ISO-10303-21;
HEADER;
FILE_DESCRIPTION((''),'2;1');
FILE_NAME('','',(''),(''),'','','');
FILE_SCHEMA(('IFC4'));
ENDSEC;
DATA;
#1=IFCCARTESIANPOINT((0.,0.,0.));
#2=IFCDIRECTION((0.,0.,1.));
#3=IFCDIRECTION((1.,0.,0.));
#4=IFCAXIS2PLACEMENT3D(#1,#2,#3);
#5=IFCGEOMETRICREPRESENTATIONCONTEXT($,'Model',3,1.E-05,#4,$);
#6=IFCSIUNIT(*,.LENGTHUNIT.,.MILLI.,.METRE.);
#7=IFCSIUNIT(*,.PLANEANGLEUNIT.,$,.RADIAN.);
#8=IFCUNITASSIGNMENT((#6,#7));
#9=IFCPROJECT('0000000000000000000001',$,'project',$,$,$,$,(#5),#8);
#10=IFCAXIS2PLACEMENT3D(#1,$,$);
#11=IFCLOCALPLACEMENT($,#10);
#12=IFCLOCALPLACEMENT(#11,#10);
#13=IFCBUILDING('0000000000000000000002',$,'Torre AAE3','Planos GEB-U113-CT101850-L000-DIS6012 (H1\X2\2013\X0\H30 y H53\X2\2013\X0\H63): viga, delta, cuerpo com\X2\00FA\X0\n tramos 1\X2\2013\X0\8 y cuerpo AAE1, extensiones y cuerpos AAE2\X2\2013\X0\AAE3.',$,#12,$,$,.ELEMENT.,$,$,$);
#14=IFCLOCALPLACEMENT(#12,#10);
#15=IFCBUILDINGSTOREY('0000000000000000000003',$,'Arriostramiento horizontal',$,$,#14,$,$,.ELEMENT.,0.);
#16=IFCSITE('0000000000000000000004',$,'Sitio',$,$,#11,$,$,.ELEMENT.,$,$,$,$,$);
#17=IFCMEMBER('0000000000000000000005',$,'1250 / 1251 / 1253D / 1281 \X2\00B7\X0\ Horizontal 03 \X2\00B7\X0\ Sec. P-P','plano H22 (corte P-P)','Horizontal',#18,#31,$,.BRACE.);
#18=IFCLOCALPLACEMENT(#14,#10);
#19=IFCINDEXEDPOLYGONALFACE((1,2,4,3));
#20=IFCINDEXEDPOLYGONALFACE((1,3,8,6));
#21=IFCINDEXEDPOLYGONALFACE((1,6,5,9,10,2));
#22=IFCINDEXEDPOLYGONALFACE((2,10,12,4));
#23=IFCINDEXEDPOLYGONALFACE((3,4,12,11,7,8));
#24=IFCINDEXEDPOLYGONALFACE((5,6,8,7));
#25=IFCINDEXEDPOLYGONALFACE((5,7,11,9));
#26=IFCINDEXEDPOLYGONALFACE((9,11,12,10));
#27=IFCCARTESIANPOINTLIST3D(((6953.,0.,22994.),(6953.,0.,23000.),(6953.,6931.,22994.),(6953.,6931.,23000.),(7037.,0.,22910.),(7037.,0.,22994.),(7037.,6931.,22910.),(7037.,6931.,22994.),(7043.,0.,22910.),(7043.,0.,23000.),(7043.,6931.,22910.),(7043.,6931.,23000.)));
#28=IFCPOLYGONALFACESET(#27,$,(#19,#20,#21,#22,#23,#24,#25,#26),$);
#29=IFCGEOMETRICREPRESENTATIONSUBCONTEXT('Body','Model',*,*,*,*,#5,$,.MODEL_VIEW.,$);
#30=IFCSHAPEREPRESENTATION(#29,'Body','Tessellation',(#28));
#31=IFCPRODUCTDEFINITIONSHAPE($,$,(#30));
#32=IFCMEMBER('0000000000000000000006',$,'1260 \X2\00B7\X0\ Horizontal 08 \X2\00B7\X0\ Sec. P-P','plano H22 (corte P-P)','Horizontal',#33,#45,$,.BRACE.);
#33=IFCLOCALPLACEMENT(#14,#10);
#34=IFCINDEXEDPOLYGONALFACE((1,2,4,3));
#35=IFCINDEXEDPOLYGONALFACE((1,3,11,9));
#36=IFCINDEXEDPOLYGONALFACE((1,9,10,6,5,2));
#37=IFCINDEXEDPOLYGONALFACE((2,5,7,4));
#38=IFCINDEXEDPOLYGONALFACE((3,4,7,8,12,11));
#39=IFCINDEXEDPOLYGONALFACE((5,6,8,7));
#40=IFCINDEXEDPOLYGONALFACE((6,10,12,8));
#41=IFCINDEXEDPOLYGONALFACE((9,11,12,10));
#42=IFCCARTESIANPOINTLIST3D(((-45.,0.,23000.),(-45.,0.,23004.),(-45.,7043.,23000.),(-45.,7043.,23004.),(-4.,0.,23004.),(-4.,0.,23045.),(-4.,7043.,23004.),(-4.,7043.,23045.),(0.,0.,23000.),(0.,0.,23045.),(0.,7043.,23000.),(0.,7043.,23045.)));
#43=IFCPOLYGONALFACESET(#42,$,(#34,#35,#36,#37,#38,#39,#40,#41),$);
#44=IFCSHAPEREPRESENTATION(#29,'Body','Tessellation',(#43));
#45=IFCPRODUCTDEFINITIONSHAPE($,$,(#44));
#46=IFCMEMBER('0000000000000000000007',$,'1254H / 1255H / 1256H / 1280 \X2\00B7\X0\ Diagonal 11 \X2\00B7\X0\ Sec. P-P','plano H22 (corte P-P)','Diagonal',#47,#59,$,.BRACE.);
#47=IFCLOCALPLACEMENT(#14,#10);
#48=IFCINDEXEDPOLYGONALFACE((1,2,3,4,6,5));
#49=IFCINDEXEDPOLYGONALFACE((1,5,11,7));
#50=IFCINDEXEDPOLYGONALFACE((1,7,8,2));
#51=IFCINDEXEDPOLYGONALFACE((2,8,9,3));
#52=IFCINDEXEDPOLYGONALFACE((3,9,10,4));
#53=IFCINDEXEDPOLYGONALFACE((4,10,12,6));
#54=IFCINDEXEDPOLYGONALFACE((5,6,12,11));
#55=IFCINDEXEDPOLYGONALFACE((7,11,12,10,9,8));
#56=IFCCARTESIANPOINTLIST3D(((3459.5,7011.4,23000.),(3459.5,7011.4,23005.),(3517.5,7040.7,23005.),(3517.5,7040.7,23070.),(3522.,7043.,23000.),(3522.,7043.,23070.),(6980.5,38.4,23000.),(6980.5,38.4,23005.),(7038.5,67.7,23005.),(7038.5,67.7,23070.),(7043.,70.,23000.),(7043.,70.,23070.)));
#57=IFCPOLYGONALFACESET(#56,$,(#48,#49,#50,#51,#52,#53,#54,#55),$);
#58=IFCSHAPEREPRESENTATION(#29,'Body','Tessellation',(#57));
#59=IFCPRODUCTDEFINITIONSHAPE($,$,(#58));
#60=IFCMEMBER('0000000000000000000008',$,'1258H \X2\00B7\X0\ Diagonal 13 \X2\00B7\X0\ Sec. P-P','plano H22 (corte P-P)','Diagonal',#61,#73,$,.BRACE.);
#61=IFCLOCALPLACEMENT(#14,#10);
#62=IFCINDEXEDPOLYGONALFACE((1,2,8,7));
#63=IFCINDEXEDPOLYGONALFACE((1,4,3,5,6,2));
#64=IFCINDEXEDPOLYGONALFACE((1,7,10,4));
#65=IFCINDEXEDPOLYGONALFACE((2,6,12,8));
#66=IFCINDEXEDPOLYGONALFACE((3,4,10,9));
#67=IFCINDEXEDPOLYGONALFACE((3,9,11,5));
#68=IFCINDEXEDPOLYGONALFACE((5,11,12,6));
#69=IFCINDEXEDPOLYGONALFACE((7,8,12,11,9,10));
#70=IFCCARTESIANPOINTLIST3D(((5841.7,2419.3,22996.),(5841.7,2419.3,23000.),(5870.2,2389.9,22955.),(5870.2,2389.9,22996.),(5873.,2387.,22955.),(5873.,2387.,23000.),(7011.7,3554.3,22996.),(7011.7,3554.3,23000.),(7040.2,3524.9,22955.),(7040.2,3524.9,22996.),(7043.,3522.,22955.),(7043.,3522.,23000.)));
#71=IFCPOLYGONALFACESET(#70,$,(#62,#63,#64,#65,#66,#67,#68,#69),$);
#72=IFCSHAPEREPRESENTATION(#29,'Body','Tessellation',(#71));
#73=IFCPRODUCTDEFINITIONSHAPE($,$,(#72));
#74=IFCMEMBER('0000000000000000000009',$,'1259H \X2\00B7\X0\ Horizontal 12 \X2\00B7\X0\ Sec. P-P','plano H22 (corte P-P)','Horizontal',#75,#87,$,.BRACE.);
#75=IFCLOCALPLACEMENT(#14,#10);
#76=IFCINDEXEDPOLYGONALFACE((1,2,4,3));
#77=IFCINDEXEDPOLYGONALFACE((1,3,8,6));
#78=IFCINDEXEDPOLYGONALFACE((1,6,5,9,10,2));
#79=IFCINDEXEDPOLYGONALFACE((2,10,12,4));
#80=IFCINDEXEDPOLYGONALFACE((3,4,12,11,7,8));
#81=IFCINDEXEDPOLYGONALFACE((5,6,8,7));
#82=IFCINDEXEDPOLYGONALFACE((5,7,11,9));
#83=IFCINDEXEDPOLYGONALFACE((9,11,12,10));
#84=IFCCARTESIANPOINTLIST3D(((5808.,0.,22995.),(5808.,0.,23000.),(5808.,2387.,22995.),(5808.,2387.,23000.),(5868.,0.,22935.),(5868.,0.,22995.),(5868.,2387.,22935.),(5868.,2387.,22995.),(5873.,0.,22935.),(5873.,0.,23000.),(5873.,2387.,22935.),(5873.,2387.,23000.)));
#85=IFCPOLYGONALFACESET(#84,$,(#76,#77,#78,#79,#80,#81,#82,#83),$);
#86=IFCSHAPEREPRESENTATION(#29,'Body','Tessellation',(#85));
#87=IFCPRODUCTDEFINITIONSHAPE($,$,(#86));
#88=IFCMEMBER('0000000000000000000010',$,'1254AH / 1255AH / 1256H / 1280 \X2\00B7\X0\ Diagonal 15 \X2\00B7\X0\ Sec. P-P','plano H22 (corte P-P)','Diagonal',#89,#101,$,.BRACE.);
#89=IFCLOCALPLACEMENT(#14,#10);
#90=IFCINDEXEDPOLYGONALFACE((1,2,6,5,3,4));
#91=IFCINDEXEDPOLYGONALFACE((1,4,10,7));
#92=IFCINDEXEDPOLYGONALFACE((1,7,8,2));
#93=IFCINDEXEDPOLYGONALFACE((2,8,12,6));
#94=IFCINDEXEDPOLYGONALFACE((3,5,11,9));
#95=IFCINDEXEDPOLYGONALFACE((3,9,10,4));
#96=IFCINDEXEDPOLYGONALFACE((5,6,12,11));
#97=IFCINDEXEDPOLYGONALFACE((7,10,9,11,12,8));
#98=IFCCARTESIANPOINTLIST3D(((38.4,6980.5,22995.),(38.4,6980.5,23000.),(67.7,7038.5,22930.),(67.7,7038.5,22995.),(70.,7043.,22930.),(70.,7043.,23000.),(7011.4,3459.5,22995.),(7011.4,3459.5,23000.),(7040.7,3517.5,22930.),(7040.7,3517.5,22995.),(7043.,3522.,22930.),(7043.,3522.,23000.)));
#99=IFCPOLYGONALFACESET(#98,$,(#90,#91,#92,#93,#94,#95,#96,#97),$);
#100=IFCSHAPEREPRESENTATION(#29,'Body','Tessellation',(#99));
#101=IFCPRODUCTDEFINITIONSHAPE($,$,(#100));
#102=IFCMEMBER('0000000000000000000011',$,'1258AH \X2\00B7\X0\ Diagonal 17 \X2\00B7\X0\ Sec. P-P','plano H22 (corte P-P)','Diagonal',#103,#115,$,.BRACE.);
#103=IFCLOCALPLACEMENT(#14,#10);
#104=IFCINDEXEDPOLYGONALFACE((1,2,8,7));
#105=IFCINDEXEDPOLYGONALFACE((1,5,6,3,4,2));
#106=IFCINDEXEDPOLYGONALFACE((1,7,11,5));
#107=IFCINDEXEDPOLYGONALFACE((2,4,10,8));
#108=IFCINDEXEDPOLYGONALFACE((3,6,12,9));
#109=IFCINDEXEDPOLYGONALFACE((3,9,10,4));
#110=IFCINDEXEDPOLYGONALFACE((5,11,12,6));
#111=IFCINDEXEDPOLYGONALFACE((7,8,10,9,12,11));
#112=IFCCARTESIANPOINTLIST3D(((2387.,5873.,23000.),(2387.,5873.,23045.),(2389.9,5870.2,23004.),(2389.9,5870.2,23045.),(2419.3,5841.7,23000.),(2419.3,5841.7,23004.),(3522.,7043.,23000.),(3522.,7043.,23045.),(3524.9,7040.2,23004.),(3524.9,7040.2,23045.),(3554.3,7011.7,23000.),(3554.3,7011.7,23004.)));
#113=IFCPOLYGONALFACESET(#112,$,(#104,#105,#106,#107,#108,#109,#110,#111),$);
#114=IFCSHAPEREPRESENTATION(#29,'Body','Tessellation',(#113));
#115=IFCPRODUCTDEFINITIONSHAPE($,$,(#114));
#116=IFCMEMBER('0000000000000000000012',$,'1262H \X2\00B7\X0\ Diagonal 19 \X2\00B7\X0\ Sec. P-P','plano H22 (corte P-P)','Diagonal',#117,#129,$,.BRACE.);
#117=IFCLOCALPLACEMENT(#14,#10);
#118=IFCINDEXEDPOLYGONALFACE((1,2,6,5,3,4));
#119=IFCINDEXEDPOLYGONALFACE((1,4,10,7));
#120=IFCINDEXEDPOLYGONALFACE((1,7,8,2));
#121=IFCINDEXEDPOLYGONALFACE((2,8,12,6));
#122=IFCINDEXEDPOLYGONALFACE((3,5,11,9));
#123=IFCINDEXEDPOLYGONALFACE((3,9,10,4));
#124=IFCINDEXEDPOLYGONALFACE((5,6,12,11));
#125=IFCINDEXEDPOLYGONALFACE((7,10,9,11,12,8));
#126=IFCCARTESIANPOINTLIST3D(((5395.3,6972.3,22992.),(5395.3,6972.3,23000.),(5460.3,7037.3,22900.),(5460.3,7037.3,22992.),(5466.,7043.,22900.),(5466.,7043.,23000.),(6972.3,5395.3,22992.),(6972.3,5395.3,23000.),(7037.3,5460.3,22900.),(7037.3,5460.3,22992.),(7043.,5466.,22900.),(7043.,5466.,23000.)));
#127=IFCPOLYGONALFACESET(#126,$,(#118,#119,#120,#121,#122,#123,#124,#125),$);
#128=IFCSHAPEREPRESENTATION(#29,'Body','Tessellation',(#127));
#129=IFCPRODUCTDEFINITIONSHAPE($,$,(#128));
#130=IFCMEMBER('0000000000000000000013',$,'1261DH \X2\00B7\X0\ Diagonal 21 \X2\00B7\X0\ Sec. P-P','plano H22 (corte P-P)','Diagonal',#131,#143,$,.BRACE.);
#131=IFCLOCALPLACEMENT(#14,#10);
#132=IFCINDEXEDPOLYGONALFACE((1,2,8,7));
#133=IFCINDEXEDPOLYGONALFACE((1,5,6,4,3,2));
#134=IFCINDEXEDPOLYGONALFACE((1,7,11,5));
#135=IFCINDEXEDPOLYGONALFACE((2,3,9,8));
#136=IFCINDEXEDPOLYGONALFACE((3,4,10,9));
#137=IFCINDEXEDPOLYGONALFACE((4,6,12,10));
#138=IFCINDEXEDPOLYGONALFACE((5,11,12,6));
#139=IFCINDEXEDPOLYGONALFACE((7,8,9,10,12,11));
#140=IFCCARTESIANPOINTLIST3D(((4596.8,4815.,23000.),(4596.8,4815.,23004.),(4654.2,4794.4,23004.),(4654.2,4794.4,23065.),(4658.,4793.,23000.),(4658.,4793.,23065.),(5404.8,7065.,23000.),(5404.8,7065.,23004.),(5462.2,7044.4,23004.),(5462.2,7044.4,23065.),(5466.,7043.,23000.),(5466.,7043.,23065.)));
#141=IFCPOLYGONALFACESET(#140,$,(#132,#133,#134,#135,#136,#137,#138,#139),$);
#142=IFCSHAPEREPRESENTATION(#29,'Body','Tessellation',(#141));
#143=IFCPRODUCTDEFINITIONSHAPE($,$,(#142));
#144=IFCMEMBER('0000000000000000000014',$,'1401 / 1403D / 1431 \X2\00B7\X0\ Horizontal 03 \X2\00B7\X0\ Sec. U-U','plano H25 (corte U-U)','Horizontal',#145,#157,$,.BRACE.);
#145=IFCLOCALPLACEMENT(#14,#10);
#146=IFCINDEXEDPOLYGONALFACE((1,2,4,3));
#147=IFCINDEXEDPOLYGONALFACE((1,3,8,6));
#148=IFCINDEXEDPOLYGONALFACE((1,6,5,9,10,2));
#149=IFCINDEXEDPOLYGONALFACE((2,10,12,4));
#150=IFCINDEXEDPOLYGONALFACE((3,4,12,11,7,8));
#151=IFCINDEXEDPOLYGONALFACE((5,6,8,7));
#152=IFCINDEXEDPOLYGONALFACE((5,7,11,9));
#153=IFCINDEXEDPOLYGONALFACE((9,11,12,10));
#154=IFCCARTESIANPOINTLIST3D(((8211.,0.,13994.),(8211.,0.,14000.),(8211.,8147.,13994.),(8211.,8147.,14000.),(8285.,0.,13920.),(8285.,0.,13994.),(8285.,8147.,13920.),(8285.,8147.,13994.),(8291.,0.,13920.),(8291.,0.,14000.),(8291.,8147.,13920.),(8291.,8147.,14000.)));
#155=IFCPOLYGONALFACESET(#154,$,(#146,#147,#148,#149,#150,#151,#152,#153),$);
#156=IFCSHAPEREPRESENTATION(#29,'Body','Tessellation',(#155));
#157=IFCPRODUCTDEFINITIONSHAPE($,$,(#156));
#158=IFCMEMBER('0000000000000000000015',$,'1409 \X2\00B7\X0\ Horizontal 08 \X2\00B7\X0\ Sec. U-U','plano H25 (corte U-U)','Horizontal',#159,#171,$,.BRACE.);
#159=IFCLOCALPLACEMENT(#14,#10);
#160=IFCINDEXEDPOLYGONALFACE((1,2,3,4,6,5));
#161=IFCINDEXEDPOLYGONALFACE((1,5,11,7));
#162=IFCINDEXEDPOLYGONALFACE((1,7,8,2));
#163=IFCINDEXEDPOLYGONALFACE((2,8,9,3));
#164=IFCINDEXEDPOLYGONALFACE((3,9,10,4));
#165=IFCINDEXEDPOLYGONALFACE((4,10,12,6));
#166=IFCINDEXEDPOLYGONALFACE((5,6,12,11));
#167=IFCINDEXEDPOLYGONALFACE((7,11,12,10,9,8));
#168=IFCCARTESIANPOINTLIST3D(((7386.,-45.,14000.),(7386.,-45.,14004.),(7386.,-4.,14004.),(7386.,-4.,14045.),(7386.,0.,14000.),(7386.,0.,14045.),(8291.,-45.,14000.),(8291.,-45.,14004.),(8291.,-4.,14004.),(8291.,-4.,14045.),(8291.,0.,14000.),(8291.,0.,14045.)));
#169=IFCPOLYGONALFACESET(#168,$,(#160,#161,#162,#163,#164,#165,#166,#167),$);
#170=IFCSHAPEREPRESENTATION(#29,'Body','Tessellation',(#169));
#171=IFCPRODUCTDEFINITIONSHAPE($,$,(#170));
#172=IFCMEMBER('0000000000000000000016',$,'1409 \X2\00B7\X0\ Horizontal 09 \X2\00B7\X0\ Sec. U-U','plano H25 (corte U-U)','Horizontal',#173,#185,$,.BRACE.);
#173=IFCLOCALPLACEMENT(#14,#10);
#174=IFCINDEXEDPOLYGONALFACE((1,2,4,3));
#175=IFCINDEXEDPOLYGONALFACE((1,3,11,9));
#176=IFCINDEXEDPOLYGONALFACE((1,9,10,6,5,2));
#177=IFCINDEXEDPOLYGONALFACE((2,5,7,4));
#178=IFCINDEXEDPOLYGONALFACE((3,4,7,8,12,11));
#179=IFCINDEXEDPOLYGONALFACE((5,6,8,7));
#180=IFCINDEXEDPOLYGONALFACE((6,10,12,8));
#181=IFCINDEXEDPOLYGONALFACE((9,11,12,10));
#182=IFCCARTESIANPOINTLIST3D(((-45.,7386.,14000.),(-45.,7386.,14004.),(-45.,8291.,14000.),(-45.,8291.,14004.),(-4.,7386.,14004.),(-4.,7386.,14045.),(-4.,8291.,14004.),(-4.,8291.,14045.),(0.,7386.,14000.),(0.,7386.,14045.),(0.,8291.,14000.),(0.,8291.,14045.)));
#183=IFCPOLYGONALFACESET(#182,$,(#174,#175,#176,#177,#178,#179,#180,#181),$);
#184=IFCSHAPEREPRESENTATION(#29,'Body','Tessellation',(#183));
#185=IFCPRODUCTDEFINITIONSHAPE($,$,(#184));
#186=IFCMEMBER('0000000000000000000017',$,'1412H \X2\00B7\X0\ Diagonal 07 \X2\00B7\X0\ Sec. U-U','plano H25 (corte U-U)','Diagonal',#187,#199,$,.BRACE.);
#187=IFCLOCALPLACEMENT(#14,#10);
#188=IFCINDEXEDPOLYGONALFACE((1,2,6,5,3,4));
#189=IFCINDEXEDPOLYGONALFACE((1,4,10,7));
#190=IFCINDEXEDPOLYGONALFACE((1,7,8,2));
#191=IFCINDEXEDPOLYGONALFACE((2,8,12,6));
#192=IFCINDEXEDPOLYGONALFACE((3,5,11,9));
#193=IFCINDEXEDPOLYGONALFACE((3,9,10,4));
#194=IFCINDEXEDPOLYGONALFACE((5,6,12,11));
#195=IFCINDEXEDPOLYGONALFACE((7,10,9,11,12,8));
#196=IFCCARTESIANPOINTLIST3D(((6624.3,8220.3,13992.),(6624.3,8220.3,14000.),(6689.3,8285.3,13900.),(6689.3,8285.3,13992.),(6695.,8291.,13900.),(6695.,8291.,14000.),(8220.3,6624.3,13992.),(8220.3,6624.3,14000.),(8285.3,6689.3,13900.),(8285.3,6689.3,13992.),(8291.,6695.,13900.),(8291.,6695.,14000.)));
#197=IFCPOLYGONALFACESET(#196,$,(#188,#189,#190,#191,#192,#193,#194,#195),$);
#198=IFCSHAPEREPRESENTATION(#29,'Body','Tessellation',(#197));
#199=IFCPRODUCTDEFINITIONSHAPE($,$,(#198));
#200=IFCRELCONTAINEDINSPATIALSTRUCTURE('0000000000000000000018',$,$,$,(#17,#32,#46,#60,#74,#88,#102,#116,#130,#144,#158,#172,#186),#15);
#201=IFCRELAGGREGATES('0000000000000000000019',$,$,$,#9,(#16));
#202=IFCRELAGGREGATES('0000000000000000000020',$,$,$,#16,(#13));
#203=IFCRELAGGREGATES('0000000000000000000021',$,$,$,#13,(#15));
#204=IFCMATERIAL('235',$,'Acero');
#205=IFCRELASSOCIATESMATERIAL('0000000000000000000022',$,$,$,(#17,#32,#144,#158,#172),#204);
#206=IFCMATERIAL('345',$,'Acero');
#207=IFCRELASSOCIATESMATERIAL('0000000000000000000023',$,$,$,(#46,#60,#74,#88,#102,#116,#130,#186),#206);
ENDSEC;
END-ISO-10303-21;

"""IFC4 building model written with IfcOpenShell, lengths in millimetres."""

from ifc_helpers import new_model, si_unit, frame, frame_2d, origin, origin_with_axes, place, context, subcontext, project, spatial, l_section, extrude, material, element, save


model = new_model("IFC4")

# Units and contexts
model_context = context("Model", 3, precision=1e-05, world=origin_with_axes())
body_context = subcontext(model_context, "Body", "Model", "MODEL_VIEW")
ifc_project = project(units=[si_unit("LENGTHUNIT", "METRE", prefix="MILLI"), si_unit("PLANEANGLEUNIT", "RADIAN")], contexts=[model_context])

# Site, building, storey
site_placement = place(None, origin())
site = spatial("IfcSite", under=ifc_project, at=site_placement, Name="Sitio", CompositionType="ELEMENT")
building_placement = place(site_placement, origin())
building = spatial("IfcBuilding", under=site, at=building_placement, Name="Torre AAE3", Description="Planos GEB-U113-CT101850-L000-DIS6012 (H1–H30 y H53–H63): viga, delta, cuerpo común tramos 1–8 y cuerpo AAE1, extensiones y cuerpos AAE2–AAE3.", CompositionType="ELEMENT")
storey_placement = place(building_placement, origin())
storey = spatial("IfcBuildingStorey", under=building, at=storey_placement, Name="Arriostramiento horizontal", CompositionType="ELEMENT", Elevation=0.0)

# Members
ifc_material_1 = material(Name="235", Category="Acero")
member_1_placement = place(storey_placement, frame((7043.0, 6931.0, 23000.0), z_axis=(0.0, -1.0, 0.0), x_axis=(-1.0, 0.0, 0.0)))
element("IfcMember", 1, at=member_1_placement, inside=storey, material=ifc_material_1, Name="1250 / 1251 / 1253D / 1281 · Horizontal 03 · Sec. P-P", Description="plano H22 (corte P-P)", ObjectType="Horizontal", PredefinedType="BRACE", context=body_context, shape_type="SweptSolid", body=[
    extrude(l_section(Depth=90.0, Width=90.0, Thickness=6.0, at=frame_2d((45.0, 45.0))), None, (0.0, 0.0, 1.0), 6931.0),
])
member_2_placement = place(storey_placement, frame((0.0, 7043.0, 23000.0), z_axis=(0.0, -1.0, 0.0), x_axis=(0.0, 0.0, 1.0)))
element("IfcMember", 2, at=member_2_placement, inside=storey, material=ifc_material_1, Name="1260 · Horizontal 08 · Sec. P-P", Description="plano H22 (corte P-P)", ObjectType="Horizontal", PredefinedType="BRACE", context=body_context, shape_type="SweptSolid", body=[
    extrude(l_section(Depth=45.0, Width=45.0, Thickness=4.0, at=frame_2d((22.5, 22.5))), None, (0.0, 0.0, 1.0), 7043.0),
])
ifc_material_2 = material(Name="345", Category="Acero")
member_3_placement = place(storey_placement, frame((7043.0, 70.0, 23000.0), z_axis=(-0.450743, 0.892654, 0.0), x_axis=(-0.892654, -0.450743, 0.0)))
element("IfcMember", 3, at=member_3_placement, inside=storey, material=ifc_material_2, Name="1254H / 1255H / 1256H / 1280 · Diagonal 11 · Sec. P-P", Description="plano H22 (corte P-P)", ObjectType="Diagonal", PredefinedType="BRACE", context=body_context, shape_type="SweptSolid", body=[
    extrude(l_section(Depth=70.0, Width=70.0, Thickness=5.0, at=frame_2d((35.0, 35.0))), None, (0.0, 0.0, 1.0), 7811.5),
])
member_4_placement = place(storey_placement, frame((7043.0, 3522.0, 23000.0), z_axis=(-0.717761, -0.69629, 0.0), x_axis=(-0.69629, 0.717761, 0.0)))
element("IfcMember", 4, at=member_4_placement, inside=storey, material=ifc_material_2, Name="1258H · Diagonal 13 · Sec. P-P", Description="plano H22 (corte P-P)", ObjectType="Diagonal", PredefinedType="BRACE", context=body_context, shape_type="SweptSolid", body=[
    extrude(l_section(Depth=45.0, Width=45.0, Thickness=4.0, at=frame_2d((22.5, 22.5))), None, (0.0, 0.0, 1.0), 1630.1),
])
member_5_placement = place(storey_placement, frame((5873.0, 2387.0, 23000.0), z_axis=(0.0, -1.0, 0.0), x_axis=(-1.0, 0.0, 0.0)))
element("IfcMember", 5, at=member_5_placement, inside=storey, material=ifc_material_2, Name="1259H · Horizontal 12 · Sec. P-P", Description="plano H22 (corte P-P)", ObjectType="Horizontal", PredefinedType="BRACE", context=body_context, shape_type="SweptSolid", body=[
    extrude(l_section(Depth=65.0, Width=65.0, Thickness=5.0, at=frame_2d((32.5, 32.5))), None, (0.0, 0.0, 1.0), 2387.0),
])
member_6_placement = place(storey_placement, frame((70.0, 7043.0, 23000.0), z_axis=(0.892654, -0.450743, 0.0), x_axis=(-0.450743, -0.892654, 0.0)))
element("IfcMember", 6, at=member_6_placement, inside=storey, material=ifc_material_2, Name="1254AH / 1255AH / 1256H / 1280 · Diagonal 15 · Sec. P-P", Description="plano H22 (corte P-P)", ObjectType="Diagonal", PredefinedType="BRACE", context=body_context, shape_type="SweptSolid", body=[
    extrude(l_section(Depth=70.0, Width=70.0, Thickness=5.0, at=frame_2d((35.0, 35.0))), None, (0.0, 0.0, 1.0), 7811.5),
])
member_7_placement = place(storey_placement, frame((3522.0, 7043.0, 23000.0), z_axis=(-0.69629, -0.717761, 0.0), x_axis=(0.717761, -0.69629, 0.0)))
element("IfcMember", 7, at=member_7_placement, inside=storey, material=ifc_material_2, Name="1258AH · Diagonal 17 · Sec. P-P", Description="plano H22 (corte P-P)", ObjectType="Diagonal", PredefinedType="BRACE", context=body_context, shape_type="SweptSolid", body=[
    extrude(l_section(Depth=45.0, Width=45.0, Thickness=4.0, at=frame_2d((22.5, 22.5))), None, (0.0, 0.0, 1.0), 1630.1),
])
member_8_placement = place(storey_placement, frame((5466.0, 7043.0, 23000.0), z_axis=(0.707107, -0.707107, 0.0), x_axis=(-0.707107, -0.707107, 0.0)))
element("IfcMember", 8, at=member_8_placement, inside=storey, material=ifc_material_2, Name="1262H · Diagonal 19 · Sec. P-P", Description="plano H22 (corte P-P)", ObjectType="Diagonal", PredefinedType="BRACE", context=body_context, shape_type="SweptSolid", body=[
    extrude(l_section(Depth=100.0, Width=100.0, Thickness=8.0, at=frame_2d((50.0, 50.0))), None, (0.0, 0.0, 1.0), 2230.2),
])
member_9_placement = place(storey_placement, frame((4658.0, 4793.0, 23000.0), z_axis=(0.337979, 0.941154, 0.0), x_axis=(-0.941154, 0.337979, 0.0)))
element("IfcMember", 9, at=member_9_placement, inside=storey, material=ifc_material_2, Name="1261DH · Diagonal 21 · Sec. P-P", Description="plano H22 (corte P-P)", ObjectType="Diagonal", PredefinedType="BRACE", context=body_context, shape_type="SweptSolid", body=[
    extrude(l_section(Depth=65.0, Width=65.0, Thickness=4.0, at=frame_2d((32.5, 32.5))), None, (0.0, 0.0, 1.0), 2390.7),
])
member_10_placement = place(storey_placement, frame((8291.0, 8147.0, 14000.0), z_axis=(0.0, -1.0, 0.0), x_axis=(-1.0, 0.0, 0.0)))
element("IfcMember", 10, at=member_10_placement, inside=storey, material=ifc_material_1, Name="1401 / 1403D / 1431 · Horizontal 03 · Sec. U-U", Description="plano H25 (corte U-U)", ObjectType="Horizontal", PredefinedType="BRACE", context=body_context, shape_type="SweptSolid", body=[
    extrude(l_section(Depth=80.0, Width=80.0, Thickness=6.0, at=frame_2d((40.0, 40.0))), None, (0.0, 0.0, 1.0), 8147.0),
])
for number, where, z_axis, x_axis, name in (
    (11, (7386.0, 0.0, 14000.0), (1.0, 0.0, 0.0), (0.0, 0.0, 1.0), "1409 · Horizontal 08 · Sec. U-U"),
    (12, (0.0, 8291.0, 14000.0), (0.0, -1.0, 0.0), (0.0, 0.0, 1.0), "1409 · Horizontal 09 · Sec. U-U"),
):
    element("IfcMember", number, at=place(storey_placement, frame(where, z_axis=z_axis, x_axis=x_axis)), inside=storey, material=ifc_material_1, Name=name, Description="plano H25 (corte U-U)", ObjectType="Horizontal", PredefinedType="BRACE", context=body_context, shape_type="SweptSolid", body=[
        extrude(l_section(Depth=45.0, Width=45.0, Thickness=4.0, at=frame_2d((22.5, 22.5))), None, (0.0, 0.0, 1.0), 905.0),
    ])
member_11_placement = place(storey_placement, frame((6695.0, 8291.0, 14000.0), z_axis=(0.707107, -0.707107, 0.0), x_axis=(-0.707107, -0.707107, 0.0)))
element("IfcMember", 13, at=member_11_placement, inside=storey, material=ifc_material_2, Name="1412H · Diagonal 07 · Sec. U-U", Description="plano H25 (corte U-U)", ObjectType="Diagonal", PredefinedType="BRACE", context=body_context, shape_type="SweptSolid", body=[
    extrude(l_section(Depth=100.0, Width=100.0, Thickness=8.0, at=frame_2d((50.0, 50.0))), None, (0.0, 0.0, 1.0), 2257.1),
])

save(model, "model.ifc")
